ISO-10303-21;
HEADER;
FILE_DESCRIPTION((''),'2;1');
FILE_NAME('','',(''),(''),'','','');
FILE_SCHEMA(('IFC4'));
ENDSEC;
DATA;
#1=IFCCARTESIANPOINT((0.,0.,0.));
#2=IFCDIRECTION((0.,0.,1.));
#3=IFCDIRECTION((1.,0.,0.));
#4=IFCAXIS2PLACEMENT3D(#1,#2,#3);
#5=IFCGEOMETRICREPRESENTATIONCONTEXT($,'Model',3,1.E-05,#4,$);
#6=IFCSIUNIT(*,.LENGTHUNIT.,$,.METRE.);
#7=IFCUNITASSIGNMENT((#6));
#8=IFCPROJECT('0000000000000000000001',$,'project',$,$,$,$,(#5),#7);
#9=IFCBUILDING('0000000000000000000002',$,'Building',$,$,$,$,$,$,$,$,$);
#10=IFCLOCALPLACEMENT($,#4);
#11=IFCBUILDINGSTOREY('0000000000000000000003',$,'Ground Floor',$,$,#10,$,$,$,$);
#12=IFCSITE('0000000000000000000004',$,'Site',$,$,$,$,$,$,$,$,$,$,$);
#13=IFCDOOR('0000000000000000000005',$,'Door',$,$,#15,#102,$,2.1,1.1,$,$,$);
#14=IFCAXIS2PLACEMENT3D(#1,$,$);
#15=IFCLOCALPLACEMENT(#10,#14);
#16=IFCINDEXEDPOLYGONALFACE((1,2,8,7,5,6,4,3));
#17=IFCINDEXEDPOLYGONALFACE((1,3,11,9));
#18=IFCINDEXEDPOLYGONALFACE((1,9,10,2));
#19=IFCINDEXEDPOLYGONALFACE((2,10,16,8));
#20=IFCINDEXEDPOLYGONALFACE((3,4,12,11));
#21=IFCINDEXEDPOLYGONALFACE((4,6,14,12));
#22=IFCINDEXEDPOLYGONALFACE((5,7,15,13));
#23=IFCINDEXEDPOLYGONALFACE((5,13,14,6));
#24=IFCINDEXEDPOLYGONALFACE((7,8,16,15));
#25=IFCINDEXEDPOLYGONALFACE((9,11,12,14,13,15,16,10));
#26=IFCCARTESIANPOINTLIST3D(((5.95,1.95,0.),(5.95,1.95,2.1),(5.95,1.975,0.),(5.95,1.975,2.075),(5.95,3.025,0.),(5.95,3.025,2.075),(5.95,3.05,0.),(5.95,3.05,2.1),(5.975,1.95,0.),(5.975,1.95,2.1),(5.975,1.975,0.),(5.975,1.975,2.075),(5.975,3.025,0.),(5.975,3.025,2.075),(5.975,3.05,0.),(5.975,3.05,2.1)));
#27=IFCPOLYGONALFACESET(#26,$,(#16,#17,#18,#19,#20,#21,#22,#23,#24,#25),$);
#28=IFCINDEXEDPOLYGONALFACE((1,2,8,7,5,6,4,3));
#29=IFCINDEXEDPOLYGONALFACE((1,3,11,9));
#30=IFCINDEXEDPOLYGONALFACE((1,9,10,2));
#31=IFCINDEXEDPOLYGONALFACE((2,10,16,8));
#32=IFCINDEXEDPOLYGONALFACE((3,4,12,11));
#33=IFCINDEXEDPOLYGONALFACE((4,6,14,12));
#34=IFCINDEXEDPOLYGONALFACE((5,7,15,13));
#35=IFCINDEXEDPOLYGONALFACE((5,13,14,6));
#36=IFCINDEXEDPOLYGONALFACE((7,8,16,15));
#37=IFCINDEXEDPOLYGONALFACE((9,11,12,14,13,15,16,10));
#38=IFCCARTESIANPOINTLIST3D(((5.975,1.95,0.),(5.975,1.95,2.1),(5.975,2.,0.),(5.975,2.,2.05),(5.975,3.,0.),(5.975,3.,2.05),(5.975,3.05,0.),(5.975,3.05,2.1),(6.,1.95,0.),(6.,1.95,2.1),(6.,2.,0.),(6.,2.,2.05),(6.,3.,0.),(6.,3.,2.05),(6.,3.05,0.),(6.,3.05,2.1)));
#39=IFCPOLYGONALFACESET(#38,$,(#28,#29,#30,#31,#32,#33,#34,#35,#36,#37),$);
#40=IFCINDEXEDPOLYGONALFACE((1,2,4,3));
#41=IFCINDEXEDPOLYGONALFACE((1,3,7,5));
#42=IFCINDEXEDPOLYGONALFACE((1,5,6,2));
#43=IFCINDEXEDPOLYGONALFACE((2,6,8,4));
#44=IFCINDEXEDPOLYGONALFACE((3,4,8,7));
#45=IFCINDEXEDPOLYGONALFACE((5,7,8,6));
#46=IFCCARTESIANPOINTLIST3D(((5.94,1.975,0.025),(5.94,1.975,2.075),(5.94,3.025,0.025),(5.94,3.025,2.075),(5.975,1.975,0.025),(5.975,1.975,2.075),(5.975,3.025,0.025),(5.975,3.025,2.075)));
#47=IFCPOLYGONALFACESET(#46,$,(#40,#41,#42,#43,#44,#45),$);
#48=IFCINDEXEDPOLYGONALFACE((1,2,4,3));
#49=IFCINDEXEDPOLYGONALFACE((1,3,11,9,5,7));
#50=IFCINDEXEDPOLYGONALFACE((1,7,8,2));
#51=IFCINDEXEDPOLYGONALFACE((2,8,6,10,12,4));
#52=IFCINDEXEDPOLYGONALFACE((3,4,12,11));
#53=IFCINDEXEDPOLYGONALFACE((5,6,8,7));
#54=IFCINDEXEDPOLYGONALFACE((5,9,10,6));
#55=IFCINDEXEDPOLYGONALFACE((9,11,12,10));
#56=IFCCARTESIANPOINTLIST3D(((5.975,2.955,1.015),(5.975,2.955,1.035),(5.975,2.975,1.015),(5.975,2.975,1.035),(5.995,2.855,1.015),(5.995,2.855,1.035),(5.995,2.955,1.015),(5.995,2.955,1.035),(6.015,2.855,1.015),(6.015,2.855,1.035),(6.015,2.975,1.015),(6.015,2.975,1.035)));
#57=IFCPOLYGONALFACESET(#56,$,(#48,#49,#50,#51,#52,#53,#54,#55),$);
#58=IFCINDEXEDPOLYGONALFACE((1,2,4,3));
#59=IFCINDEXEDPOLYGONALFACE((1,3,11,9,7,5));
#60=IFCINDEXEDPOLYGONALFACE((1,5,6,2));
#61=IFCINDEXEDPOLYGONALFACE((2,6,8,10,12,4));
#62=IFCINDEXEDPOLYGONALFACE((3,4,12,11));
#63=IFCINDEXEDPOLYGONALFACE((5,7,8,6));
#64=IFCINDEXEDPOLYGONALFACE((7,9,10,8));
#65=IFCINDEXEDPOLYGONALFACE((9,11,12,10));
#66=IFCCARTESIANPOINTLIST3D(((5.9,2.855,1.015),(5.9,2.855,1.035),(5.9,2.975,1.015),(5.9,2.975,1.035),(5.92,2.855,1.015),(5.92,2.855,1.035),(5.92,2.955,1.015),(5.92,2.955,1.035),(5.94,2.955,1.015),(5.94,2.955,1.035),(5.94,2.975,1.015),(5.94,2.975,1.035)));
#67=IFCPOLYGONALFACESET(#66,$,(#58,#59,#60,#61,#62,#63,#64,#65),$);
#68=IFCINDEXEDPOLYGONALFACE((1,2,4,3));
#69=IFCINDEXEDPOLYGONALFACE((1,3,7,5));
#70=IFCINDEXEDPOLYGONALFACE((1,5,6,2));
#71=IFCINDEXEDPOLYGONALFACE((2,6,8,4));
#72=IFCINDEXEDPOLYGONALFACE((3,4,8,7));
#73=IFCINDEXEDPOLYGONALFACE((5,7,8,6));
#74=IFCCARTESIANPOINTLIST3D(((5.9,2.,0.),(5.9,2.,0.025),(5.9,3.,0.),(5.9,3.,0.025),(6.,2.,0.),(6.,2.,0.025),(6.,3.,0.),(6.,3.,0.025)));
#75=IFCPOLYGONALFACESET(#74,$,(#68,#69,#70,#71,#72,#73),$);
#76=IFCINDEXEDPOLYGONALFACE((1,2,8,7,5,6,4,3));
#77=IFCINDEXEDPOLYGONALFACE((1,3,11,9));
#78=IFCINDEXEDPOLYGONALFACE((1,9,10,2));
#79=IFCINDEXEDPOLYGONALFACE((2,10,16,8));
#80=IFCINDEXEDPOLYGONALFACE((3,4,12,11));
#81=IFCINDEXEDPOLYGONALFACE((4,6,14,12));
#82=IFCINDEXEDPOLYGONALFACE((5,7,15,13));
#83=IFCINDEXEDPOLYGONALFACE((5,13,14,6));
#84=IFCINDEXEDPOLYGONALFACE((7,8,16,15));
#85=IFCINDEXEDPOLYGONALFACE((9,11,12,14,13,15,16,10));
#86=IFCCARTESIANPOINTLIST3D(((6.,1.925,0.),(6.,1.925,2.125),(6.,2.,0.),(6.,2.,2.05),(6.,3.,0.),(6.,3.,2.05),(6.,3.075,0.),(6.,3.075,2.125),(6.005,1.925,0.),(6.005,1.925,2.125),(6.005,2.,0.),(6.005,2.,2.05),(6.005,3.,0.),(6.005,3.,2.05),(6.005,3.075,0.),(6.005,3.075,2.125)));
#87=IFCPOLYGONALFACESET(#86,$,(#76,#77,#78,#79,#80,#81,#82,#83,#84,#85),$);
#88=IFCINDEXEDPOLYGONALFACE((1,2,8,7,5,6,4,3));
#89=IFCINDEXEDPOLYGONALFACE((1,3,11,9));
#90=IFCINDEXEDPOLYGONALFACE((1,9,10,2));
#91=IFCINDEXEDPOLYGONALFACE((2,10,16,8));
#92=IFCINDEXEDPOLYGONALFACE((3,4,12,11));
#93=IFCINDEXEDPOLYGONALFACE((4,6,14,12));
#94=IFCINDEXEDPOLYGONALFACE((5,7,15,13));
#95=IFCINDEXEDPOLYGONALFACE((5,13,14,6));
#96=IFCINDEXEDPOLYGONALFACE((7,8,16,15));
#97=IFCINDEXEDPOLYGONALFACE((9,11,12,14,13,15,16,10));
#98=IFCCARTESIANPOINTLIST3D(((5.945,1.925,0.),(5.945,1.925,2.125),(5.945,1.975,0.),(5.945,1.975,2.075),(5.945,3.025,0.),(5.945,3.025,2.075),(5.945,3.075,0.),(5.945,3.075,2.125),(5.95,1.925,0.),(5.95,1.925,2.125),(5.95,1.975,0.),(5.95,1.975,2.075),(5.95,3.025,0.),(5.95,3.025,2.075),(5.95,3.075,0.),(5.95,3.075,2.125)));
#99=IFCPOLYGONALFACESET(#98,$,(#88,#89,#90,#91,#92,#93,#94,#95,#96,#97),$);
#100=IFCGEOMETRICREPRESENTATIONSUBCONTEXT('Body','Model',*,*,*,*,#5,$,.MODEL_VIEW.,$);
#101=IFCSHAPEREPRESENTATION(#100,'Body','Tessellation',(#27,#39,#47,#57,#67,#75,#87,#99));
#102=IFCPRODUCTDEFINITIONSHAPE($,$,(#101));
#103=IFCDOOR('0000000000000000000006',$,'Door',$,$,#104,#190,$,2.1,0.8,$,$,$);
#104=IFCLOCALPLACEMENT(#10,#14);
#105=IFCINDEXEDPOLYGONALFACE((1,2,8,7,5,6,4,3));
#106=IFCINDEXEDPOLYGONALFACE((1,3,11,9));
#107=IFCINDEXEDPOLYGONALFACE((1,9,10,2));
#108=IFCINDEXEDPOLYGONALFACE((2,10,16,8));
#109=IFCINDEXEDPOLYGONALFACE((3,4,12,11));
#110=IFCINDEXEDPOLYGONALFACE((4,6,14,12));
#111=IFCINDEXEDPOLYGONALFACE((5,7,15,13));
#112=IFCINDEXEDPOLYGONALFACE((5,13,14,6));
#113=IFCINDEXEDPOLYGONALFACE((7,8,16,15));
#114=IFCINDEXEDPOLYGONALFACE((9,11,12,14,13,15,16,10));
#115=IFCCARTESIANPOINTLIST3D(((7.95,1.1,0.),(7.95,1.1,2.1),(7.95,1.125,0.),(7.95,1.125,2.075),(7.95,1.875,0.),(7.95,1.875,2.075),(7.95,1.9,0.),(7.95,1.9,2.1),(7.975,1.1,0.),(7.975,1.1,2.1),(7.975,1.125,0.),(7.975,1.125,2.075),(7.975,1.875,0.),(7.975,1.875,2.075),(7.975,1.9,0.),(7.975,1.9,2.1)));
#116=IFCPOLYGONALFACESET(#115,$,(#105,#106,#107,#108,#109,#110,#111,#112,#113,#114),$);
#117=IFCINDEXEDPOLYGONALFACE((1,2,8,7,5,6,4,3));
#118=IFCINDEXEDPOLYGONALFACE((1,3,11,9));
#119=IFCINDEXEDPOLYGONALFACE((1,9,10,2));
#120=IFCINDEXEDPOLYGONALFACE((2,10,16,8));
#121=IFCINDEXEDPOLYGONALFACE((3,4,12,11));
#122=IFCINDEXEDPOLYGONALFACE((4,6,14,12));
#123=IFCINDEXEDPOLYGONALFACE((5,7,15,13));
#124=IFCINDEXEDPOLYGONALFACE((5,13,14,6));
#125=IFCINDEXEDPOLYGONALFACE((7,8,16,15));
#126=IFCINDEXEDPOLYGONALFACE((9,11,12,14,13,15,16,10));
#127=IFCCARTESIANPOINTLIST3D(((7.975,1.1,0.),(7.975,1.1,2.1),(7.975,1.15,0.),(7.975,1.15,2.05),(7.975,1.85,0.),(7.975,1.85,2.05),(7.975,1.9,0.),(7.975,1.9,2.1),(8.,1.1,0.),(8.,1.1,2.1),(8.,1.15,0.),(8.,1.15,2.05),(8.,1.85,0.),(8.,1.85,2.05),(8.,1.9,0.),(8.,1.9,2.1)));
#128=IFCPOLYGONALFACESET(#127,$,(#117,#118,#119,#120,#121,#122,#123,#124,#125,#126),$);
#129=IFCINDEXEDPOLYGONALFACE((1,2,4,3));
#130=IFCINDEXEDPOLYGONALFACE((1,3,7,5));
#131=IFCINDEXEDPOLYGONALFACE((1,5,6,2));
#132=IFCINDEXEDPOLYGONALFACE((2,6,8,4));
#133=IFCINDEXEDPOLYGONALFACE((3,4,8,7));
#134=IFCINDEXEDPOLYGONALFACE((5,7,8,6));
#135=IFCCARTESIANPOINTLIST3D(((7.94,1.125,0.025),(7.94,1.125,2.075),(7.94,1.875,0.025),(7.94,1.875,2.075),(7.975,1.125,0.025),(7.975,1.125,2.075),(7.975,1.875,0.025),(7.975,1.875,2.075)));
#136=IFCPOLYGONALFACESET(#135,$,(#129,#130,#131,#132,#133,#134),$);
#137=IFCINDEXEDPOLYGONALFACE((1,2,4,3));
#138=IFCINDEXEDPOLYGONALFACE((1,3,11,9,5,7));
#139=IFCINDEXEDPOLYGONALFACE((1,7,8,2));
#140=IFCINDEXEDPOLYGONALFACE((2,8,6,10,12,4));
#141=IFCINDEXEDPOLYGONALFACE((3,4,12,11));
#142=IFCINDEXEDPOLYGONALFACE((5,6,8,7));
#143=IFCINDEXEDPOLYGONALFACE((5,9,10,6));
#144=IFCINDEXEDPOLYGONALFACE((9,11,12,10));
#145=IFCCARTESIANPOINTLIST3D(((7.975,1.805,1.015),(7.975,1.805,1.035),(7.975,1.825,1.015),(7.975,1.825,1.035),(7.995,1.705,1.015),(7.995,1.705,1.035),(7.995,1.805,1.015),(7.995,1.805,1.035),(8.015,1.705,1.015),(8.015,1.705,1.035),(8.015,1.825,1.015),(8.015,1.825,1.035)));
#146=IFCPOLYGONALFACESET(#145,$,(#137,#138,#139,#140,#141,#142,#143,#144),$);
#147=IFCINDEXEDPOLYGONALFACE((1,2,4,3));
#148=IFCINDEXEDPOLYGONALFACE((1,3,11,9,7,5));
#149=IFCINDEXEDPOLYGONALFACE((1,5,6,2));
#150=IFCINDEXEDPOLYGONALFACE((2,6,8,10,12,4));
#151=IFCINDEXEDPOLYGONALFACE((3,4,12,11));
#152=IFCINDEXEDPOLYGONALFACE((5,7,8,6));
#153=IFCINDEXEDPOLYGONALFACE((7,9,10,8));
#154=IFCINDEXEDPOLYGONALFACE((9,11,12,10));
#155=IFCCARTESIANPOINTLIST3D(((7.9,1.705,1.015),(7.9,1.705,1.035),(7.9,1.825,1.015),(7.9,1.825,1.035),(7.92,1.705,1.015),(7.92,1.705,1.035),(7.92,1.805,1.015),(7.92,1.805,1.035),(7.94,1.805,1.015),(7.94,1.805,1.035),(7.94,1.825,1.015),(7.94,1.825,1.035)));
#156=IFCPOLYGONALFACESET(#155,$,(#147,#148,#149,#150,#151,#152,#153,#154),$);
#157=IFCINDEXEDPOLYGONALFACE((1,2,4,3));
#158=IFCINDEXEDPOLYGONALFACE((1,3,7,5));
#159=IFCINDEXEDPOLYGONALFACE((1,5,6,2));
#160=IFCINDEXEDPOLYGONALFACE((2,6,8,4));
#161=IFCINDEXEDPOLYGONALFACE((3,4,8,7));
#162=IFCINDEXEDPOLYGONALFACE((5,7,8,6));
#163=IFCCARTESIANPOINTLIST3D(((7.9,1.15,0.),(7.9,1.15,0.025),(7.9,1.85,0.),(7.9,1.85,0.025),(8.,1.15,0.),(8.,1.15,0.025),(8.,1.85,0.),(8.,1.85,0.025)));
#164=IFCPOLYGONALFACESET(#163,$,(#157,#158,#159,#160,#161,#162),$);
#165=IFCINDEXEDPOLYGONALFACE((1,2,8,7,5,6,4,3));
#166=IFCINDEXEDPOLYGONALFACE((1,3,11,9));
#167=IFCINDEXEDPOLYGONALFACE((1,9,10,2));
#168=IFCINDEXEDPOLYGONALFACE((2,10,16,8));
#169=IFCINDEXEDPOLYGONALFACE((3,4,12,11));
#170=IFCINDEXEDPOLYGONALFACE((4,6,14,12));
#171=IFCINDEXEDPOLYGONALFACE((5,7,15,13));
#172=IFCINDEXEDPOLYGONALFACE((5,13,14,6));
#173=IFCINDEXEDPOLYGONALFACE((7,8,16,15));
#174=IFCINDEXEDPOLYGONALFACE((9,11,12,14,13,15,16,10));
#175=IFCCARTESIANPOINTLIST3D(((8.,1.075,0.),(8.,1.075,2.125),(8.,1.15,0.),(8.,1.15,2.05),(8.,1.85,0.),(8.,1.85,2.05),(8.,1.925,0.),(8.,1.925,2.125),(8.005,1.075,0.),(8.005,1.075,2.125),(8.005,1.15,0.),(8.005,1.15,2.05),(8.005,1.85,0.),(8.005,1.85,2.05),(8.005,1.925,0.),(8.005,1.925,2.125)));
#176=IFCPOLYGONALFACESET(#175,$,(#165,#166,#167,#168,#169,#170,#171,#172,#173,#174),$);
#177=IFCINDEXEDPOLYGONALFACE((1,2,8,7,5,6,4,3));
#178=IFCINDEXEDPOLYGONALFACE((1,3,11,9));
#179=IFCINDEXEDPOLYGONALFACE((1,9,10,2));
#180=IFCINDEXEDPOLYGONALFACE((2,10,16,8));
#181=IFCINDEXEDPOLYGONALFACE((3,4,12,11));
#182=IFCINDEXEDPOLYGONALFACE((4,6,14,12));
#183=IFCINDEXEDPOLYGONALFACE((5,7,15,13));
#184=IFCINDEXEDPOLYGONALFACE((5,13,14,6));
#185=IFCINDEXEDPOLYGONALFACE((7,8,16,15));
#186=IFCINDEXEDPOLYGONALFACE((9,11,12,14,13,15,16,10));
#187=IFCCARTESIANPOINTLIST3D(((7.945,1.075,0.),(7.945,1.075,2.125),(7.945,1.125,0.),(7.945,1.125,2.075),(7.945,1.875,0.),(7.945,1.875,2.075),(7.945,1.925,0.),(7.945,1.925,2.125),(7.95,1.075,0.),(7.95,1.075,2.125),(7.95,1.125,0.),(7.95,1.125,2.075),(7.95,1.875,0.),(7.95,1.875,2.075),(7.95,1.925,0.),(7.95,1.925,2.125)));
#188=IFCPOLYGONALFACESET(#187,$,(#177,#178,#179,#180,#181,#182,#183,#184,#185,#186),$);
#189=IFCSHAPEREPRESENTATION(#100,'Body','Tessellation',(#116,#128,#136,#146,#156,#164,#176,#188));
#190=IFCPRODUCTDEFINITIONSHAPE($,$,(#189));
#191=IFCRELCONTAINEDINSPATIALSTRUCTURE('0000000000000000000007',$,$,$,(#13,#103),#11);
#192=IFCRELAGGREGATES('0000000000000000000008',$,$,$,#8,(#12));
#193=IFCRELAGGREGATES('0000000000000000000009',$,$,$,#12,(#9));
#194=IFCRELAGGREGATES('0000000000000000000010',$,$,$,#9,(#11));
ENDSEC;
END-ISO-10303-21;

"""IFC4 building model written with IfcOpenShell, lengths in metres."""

from ifc_helpers import new_model, si_unit, frame, origin_with_axes, place, context, subcontext, project, spatial, line, indexed_curve, outline, extrude, element, save


model = new_model("IFC4")

# Units and contexts
model_context = context("Model", 3, precision=1e-05, world=origin_with_axes())
body_context = subcontext(model_context, "Body", "Model", "MODEL_VIEW")
ifc_project = project(units=[si_unit("LENGTHUNIT", "METRE")], contexts=[model_context])

# Site, building, storey
site = spatial("IfcSite", under=ifc_project, Name="Site")
building = spatial("IfcBuilding", under=site, Name="Building")
storey_placement = place(None, origin_with_axes())
storey = spatial("IfcBuildingStorey", under=building, at=storey_placement, Name="Ground Floor")

# Doors
door_1_placement = place(storey_placement, frame((6.0, 1.95, 0.0), z_axis=(0.0, 0.0, 1.0), x_axis=(0.0, 1.0, 0.0)))
element("IfcDoor", 1, at=door_1_placement, inside=storey, Name="Door", OverallHeight=2.1, OverallWidth=1.1, context=body_context, shape_type="SweptSolid", body=[
    extrude(outline(indexed_curve([(0.0, 0.0), (0.0, 2.1), (1.1, 2.1), (1.1, 0.0), (1.075, 0.0), (1.075, 2.075), (0.025, 2.075), (0.025, 0.0)], segments=[line(1, 2, 3, 4, 5, 6, 7, 8, 1)])), frame((0.0, 0.025, 0.0), z_axis=(0.0, -1.0, 0.0), x_axis=(1.0, 0.0, 0.0)), (0.0, 0.0, -1.0), 0.025),
    extrude(outline(indexed_curve([(0.0, 0.0), (0.0, 2.1), (1.1, 2.1), (1.1, 0.0), (1.05, 0.0), (1.05, 2.05), (0.05, 2.05), (0.05, 0.0)], segments=[line(1, 2, 3, 4, 5, 6, 7, 8, 1)])), frame((0.0, 0.0, 0.0), z_axis=(0.0, -1.0, 0.0), x_axis=(1.0, 0.0, 0.0)), (0.0, 0.0, -1.0), 0.025),
    extrude(outline(indexed_curve([(0.0, 0.0), (1.05, 0.0), (1.05, 0.035), (0.0, 0.035)], segments=[line(1, 2, 3, 4, 1)])), frame((0.025, 0.025, 0.025), z_axis=(0.0, 0.0, 1.0), x_axis=(1.0, 0.0, 0.0)), (0.0, 0.0, 1.0), 2.05),
    extrude(outline(indexed_curve([(0.0, 0.0), (0.0, -0.04), (-0.12, -0.04), (-0.12, -0.02), (-0.02, -0.02), (-0.02, 0.0)], segments=[line(1, 2, 3, 4, 5, 6, 1)])), frame((1.025, 0.025, 1.015), z_axis=(0.0, 0.0, 1.0), x_axis=(1.0, 0.0, 0.0)), (0.0, 0.0, 1.0), 0.02),
    extrude(outline(indexed_curve([(0.0, 0.0), (0.0, 0.04), (-0.12, 0.04), (-0.12, 0.02), (-0.02, 0.02), (-0.02, 0.0)], segments=[line(1, 2, 3, 4, 5, 6, 1)])), frame((1.025, 0.06, 1.015), z_axis=(0.0, 0.0, 1.0), x_axis=(1.0, 0.0, 0.0)), (0.0, 0.0, 1.0), 0.02),
    extrude(outline(indexed_curve([(0.0, 0.0), (1.0, 0.0), (1.0, 0.1), (0.0, 0.1)], segments=[line(1, 2, 3, 4, 1)])), frame((0.05, 0.0, 0.0), z_axis=(0.0, 0.0, 1.0), x_axis=(1.0, 0.0, 0.0)), (0.0, 0.0, 1.0), 0.025),
    extrude(outline(indexed_curve([(0.0, 0.0), (0.0, 2.125), (1.15, 2.125), (1.15, 0.0), (1.075, 0.0), (1.075, 2.05), (0.075, 2.05), (0.075, 0.0)], segments=[line(1, 2, 3, 4, 5, 6, 7, 8, 1)])), frame((-0.025, -0.005, 0.0), z_axis=(0.0, -1.0, 0.0), x_axis=(1.0, 0.0, 0.0)), (0.0, 0.0, -1.0), 0.005),
    extrude(outline(indexed_curve([(0.0, 0.0), (0.0, 2.125), (1.15, 2.125), (1.15, 0.0), (1.1, 0.0), (1.1, 2.075), (0.05, 2.075), (0.05, 0.0)], segments=[line(1, 2, 3, 4, 5, 6, 7, 8, 1)])), frame((-0.025, 0.05, 0.0), z_axis=(0.0, -1.0, 0.0), x_axis=(1.0, 0.0, 0.0)), (0.0, 0.0, -1.0), 0.005),
])
door_2_placement = place(storey_placement, frame((8.0, 1.1, 0.0), z_axis=(0.0, 0.0, 1.0), x_axis=(0.0, 1.0, 0.0)))
element("IfcDoor", 2, at=door_2_placement, inside=storey, Name="Door", OverallHeight=2.1, OverallWidth=0.8, context=body_context, shape_type="SweptSolid", body=[
    extrude(outline(indexed_curve([(0.0, 0.0), (0.0, 2.1), (0.8, 2.1), (0.8, 0.0), (0.775, 0.0), (0.775, 2.075), (0.025, 2.075), (0.025, 0.0)], segments=[line(1, 2, 3, 4, 5, 6, 7, 8, 1)])), frame((0.0, 0.025, 0.0), z_axis=(0.0, -1.0, 0.0), x_axis=(1.0, 0.0, 0.0)), (0.0, 0.0, -1.0), 0.025),
    extrude(outline(indexed_curve([(0.0, 0.0), (0.0, 2.1), (0.8, 2.1), (0.8, 0.0), (0.75, 0.0), (0.75, 2.05), (0.05, 2.05), (0.05, 0.0)], segments=[line(1, 2, 3, 4, 5, 6, 7, 8, 1)])), frame((0.0, 0.0, 0.0), z_axis=(0.0, -1.0, 0.0), x_axis=(1.0, 0.0, 0.0)), (0.0, 0.0, -1.0), 0.025),
    extrude(outline(indexed_curve([(0.0, 0.0), (0.75, 0.0), (0.75, 0.035), (0.0, 0.035)], segments=[line(1, 2, 3, 4, 1)])), frame((0.025, 0.025, 0.025), z_axis=(0.0, 0.0, 1.0), x_axis=(1.0, 0.0, 0.0)), (0.0, 0.0, 1.0), 2.05),
    extrude(outline(indexed_curve([(0.0, 0.0), (0.0, -0.04), (-0.12, -0.04), (-0.12, -0.02), (-0.02, -0.02), (-0.02, 0.0)], segments=[line(1, 2, 3, 4, 5, 6, 1)])), frame((0.725, 0.025, 1.015), z_axis=(0.0, 0.0, 1.0), x_axis=(1.0, 0.0, 0.0)), (0.0, 0.0, 1.0), 0.02),
    extrude(outline(indexed_curve([(0.0, 0.0), (0.0, 0.04), (-0.12, 0.04), (-0.12, 0.02), (-0.02, 0.02), (-0.02, 0.0)], segments=[line(1, 2, 3, 4, 5, 6, 1)])), frame((0.725, 0.06, 1.015), z_axis=(0.0, 0.0, 1.0), x_axis=(1.0, 0.0, 0.0)), (0.0, 0.0, 1.0), 0.02),
    extrude(outline(indexed_curve([(0.0, 0.0), (0.7, 0.0), (0.7, 0.1), (0.0, 0.1)], segments=[line(1, 2, 3, 4, 1)])), frame((0.05, 0.0, 0.0), z_axis=(0.0, 0.0, 1.0), x_axis=(1.0, 0.0, 0.0)), (0.0, 0.0, 1.0), 0.025),
    extrude(outline(indexed_curve([(0.0, 0.0), (0.0, 2.125), (0.85, 2.125), (0.85, 0.0), (0.775, 0.0), (0.775, 2.05), (0.075, 2.05), (0.075, 0.0)], segments=[line(1, 2, 3, 4, 5, 6, 7, 8, 1)])), frame((-0.025, -0.005, 0.0), z_axis=(0.0, -1.0, 0.0), x_axis=(1.0, 0.0, 0.0)), (0.0, 0.0, -1.0), 0.005),
    extrude(outline(indexed_curve([(0.0, 0.0), (0.0, 2.125), (0.85, 2.125), (0.85, 0.0), (0.8, 0.0), (0.8, 2.075), (0.05, 2.075), (0.05, 0.0)], segments=[line(1, 2, 3, 4, 5, 6, 7, 8, 1)])), frame((-0.025, 0.05, 0.0), z_axis=(0.0, -1.0, 0.0), x_axis=(1.0, 0.0, 0.0)), (0.0, 0.0, -1.0), 0.005),
])

save(model, "model.ifc")
